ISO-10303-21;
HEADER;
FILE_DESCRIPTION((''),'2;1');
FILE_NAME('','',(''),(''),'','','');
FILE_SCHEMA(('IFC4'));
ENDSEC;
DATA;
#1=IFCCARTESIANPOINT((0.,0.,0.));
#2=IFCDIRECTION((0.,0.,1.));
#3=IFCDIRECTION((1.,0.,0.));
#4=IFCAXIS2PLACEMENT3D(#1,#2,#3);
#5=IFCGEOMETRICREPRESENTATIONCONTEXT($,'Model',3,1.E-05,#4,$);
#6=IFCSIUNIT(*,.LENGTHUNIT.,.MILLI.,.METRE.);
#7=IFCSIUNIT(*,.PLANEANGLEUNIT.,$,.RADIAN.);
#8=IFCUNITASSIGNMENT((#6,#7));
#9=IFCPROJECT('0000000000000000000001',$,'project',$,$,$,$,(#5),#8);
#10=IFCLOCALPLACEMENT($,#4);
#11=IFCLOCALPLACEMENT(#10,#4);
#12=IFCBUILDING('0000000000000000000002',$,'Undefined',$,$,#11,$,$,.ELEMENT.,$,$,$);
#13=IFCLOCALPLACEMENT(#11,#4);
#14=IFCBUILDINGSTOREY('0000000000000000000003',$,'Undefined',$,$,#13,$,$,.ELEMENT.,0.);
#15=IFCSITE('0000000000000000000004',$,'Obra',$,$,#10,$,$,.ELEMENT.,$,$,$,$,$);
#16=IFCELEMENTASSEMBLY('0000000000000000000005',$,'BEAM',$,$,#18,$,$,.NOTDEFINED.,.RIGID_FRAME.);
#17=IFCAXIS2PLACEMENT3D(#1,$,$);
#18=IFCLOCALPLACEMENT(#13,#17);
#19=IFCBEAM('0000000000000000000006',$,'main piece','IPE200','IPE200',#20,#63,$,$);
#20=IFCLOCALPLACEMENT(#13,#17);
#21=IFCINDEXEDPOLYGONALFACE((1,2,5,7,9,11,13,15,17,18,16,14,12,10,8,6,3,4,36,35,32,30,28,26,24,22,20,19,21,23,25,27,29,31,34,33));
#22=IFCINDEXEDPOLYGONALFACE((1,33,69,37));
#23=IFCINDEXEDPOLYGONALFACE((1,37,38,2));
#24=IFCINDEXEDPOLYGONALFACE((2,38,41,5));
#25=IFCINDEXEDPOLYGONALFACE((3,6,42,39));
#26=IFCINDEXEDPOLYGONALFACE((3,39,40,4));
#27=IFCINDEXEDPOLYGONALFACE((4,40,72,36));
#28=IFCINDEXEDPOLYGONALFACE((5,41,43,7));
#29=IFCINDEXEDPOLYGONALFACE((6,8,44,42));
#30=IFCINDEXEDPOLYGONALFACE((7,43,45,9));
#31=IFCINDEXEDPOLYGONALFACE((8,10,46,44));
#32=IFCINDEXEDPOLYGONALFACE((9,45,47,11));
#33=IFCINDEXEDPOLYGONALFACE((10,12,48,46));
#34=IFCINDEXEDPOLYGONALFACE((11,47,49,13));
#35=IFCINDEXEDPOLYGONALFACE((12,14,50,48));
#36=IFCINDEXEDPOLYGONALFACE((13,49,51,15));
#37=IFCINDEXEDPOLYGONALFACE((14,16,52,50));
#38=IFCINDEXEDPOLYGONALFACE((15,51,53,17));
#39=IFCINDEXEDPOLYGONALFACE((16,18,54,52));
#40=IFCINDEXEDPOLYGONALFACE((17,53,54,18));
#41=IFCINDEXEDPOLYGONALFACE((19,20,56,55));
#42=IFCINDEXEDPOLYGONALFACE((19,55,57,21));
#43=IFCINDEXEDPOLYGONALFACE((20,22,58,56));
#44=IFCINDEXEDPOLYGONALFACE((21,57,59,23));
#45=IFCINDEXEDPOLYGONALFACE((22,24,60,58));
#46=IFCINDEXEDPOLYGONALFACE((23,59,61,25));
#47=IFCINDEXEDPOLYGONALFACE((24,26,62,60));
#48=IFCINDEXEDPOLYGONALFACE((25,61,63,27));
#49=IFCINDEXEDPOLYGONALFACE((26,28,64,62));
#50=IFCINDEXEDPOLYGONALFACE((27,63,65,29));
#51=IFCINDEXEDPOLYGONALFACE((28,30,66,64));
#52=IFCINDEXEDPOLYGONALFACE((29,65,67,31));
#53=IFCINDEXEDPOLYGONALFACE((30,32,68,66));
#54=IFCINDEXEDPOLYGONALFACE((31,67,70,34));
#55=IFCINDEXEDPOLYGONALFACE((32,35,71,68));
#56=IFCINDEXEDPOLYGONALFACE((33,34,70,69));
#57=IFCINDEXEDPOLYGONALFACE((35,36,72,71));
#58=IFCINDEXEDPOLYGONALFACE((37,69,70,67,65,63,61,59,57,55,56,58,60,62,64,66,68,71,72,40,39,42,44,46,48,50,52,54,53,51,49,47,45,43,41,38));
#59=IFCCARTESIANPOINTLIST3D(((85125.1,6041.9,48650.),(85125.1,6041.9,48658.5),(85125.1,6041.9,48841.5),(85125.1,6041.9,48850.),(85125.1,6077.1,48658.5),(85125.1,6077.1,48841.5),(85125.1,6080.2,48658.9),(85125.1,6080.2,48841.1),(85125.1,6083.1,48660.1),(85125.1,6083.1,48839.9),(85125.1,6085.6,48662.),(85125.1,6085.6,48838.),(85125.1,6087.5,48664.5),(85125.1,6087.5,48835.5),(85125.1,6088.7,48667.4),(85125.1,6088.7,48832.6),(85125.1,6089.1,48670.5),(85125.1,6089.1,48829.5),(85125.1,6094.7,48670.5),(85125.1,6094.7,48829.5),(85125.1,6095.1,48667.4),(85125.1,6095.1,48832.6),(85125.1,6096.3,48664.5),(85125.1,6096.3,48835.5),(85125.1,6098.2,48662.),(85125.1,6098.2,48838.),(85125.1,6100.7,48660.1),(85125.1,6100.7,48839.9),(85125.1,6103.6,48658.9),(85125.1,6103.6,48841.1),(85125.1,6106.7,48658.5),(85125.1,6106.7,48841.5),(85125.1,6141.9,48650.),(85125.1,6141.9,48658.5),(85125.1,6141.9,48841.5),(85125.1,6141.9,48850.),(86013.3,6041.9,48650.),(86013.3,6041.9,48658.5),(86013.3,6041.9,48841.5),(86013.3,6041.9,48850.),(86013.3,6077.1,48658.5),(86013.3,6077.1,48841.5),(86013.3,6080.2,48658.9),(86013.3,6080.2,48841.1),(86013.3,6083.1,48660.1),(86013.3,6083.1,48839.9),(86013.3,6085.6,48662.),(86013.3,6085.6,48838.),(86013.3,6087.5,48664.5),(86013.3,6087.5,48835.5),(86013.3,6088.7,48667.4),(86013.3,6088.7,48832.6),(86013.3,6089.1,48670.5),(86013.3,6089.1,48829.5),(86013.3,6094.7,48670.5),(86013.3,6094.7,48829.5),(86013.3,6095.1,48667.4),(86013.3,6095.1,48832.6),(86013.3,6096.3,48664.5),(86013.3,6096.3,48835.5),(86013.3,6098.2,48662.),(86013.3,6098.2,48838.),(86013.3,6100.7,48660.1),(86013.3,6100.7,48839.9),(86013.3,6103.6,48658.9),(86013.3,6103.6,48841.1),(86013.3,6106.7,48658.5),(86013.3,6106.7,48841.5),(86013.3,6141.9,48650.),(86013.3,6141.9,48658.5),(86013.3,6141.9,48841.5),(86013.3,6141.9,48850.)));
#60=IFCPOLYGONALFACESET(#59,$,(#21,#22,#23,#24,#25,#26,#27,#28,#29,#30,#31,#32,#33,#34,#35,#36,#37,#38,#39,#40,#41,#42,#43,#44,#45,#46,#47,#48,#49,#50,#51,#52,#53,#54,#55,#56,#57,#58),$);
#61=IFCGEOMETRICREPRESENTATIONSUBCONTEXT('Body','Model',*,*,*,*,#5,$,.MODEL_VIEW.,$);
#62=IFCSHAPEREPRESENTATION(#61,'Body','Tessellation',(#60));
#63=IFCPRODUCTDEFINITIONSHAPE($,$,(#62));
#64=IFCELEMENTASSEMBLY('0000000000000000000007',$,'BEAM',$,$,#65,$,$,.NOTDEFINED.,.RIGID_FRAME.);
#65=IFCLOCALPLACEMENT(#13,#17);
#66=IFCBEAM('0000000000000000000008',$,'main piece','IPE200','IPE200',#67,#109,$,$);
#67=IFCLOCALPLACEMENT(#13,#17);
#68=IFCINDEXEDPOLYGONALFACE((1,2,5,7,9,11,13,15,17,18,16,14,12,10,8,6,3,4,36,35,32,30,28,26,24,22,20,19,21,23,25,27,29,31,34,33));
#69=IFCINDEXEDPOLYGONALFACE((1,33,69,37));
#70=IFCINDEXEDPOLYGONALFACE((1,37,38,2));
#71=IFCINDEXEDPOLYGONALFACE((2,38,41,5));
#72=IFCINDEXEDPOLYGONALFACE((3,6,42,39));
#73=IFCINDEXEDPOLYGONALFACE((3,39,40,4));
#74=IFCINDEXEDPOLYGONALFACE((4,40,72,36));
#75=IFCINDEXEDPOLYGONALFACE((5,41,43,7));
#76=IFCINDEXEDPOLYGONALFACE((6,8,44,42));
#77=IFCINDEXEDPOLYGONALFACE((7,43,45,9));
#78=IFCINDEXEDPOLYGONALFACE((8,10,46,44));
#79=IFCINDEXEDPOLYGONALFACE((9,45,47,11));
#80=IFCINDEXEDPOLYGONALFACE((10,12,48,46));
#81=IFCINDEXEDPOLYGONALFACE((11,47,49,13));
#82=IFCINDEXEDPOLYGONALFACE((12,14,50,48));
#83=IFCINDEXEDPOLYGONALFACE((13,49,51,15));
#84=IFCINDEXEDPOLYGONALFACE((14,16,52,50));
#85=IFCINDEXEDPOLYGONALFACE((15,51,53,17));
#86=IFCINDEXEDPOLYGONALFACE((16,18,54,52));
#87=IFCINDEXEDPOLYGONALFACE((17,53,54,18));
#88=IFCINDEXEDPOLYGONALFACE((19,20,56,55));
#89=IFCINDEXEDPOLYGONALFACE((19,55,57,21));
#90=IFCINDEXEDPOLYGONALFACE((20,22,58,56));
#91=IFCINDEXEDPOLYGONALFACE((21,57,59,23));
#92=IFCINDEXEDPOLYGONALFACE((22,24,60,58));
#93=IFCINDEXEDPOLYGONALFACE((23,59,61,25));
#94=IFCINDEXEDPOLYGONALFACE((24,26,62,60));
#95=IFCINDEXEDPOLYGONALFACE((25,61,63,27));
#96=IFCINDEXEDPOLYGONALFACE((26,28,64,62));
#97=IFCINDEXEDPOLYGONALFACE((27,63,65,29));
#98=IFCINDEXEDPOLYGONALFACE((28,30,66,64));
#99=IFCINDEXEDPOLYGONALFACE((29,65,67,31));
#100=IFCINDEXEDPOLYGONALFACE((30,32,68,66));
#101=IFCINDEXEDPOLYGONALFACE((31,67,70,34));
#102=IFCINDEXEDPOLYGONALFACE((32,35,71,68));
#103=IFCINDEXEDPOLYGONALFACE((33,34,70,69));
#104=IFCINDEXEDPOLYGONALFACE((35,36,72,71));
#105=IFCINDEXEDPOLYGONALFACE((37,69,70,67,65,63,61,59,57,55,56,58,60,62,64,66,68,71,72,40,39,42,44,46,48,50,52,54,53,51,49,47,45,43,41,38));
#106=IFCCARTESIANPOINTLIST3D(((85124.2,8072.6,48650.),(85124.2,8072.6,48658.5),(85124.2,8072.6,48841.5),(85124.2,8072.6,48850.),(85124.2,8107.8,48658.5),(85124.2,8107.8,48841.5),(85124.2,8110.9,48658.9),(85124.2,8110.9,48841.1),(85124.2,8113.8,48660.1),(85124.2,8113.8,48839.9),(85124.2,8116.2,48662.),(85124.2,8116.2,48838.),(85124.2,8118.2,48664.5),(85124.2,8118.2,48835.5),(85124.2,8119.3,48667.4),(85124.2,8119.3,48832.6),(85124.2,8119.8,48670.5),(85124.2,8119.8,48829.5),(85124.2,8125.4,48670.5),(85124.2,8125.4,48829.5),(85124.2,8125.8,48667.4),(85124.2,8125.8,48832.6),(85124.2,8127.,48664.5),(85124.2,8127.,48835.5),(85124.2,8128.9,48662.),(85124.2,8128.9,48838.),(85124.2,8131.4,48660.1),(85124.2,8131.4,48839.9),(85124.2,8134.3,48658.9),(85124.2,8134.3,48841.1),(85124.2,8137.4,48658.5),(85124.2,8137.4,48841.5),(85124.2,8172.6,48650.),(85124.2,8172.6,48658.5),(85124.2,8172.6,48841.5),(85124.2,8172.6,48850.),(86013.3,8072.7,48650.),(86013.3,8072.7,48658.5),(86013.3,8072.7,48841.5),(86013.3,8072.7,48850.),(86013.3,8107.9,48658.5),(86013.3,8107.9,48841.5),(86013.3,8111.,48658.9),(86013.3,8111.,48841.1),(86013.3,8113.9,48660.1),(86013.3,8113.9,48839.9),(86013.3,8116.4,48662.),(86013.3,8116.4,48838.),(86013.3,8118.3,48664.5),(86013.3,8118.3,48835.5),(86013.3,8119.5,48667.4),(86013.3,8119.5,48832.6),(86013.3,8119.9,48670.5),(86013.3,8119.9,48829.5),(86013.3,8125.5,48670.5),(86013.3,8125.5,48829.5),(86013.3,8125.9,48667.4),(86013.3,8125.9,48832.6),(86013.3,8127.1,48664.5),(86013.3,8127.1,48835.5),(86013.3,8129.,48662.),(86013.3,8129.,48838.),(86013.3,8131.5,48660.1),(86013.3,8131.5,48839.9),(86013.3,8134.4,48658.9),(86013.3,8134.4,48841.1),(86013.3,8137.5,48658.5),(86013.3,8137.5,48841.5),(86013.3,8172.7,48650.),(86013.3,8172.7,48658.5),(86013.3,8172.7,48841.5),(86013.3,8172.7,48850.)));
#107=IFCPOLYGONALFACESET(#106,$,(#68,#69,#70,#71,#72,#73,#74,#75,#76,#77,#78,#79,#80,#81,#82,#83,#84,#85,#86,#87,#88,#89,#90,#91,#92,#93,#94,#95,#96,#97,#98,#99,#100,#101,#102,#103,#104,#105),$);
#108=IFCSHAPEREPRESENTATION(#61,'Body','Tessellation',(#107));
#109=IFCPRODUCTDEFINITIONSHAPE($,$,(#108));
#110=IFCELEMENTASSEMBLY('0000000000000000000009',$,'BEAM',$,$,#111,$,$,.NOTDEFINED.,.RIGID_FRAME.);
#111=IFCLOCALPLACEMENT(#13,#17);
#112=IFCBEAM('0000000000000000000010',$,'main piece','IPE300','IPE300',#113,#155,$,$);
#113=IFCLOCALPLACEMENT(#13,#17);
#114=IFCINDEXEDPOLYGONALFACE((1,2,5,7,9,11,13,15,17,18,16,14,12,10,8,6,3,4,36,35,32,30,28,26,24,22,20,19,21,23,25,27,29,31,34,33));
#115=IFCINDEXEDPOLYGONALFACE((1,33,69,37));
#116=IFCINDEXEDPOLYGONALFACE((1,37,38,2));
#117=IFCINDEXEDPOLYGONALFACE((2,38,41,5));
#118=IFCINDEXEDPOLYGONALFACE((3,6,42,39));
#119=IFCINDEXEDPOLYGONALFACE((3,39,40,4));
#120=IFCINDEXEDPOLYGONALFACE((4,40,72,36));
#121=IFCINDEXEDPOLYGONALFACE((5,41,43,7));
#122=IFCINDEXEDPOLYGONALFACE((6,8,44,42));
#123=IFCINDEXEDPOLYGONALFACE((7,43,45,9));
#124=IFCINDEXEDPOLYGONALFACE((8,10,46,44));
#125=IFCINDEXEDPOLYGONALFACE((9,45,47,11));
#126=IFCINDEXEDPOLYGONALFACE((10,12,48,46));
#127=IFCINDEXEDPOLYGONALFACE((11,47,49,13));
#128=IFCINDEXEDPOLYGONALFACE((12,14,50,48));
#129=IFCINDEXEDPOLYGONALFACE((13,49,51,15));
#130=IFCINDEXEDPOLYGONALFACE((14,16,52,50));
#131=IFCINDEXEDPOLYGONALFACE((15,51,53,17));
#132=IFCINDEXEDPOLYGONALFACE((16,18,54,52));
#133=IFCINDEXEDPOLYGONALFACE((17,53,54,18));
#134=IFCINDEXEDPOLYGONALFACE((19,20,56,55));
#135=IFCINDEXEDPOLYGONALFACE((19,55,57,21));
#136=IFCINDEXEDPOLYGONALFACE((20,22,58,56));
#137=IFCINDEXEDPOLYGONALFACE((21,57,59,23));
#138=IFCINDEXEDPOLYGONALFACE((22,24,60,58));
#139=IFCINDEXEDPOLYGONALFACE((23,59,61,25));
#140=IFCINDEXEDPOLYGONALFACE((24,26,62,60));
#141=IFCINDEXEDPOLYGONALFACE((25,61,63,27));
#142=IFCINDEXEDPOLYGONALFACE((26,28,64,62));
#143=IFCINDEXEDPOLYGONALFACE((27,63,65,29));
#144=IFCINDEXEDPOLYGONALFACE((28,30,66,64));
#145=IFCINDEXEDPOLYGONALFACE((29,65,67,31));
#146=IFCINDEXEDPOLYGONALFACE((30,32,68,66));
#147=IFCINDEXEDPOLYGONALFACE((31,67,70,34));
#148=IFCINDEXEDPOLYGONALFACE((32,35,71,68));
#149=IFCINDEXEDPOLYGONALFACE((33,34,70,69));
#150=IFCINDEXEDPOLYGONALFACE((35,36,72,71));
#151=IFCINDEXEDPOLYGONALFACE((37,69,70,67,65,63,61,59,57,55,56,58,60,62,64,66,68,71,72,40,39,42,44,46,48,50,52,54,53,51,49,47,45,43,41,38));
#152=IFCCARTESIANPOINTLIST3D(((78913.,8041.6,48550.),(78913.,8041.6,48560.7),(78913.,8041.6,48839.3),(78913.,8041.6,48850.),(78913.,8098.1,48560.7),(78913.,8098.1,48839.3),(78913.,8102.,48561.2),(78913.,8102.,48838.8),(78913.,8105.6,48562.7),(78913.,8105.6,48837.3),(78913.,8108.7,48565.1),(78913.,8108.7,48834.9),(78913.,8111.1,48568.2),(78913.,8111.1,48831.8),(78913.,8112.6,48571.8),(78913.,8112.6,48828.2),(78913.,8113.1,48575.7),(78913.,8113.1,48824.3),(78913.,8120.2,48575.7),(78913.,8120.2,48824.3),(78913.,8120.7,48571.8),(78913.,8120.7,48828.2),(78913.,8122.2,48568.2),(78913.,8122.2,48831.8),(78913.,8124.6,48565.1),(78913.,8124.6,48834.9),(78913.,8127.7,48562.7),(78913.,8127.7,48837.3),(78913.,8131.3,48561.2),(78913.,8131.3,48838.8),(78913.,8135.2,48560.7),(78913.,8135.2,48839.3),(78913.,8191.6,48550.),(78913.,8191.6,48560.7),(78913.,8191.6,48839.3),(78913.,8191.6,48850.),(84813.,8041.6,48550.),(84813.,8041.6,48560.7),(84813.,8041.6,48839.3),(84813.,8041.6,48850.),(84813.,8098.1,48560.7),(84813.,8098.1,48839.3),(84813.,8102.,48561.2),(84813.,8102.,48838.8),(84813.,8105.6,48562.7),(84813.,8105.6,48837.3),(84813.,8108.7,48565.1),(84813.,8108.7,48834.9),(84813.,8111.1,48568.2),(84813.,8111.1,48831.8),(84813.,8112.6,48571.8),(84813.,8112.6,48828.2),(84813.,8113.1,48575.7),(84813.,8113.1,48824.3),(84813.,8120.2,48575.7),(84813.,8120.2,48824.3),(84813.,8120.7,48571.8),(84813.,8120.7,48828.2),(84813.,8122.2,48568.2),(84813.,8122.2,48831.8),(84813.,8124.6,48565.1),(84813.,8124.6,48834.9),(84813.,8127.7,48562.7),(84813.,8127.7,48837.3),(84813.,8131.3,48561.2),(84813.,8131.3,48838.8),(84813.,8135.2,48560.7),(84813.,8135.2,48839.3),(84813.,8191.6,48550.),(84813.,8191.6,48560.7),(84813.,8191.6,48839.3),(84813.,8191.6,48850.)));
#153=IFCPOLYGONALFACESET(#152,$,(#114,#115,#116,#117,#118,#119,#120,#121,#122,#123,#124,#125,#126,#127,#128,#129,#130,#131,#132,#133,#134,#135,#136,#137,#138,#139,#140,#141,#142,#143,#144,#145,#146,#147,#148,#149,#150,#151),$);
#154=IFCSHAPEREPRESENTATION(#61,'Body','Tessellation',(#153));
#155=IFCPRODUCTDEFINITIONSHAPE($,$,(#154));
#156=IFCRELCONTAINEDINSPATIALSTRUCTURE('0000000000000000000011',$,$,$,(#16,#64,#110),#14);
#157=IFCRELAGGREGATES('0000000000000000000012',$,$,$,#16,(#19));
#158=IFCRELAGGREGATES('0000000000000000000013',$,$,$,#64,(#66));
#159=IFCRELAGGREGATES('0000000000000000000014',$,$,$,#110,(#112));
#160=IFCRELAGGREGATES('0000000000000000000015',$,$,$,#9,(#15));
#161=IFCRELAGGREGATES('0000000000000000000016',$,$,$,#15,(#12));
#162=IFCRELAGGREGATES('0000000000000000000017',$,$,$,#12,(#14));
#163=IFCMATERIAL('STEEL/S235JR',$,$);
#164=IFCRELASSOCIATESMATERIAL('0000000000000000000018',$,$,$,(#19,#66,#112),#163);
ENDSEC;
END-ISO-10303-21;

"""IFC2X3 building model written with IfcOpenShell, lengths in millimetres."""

from ifc_helpers import new_model, si_unit, frame, origin_with_axes, origin_2d_with_axis, place, context, subcontext, project, spatial, i_section, extrude, material, element, aggregate, save


model = new_model("IFC2X3")

# Units and contexts
model_context = context("Model", 3, precision=1e-05, world=origin_with_axes())
body_context = subcontext(model_context, "Body", "Model", "MODEL_VIEW")
ifc_project = project(units=[si_unit("LENGTHUNIT", "METRE", prefix="MILLI"), si_unit("PLANEANGLEUNIT", "RADIAN")], contexts=[model_context])

# Site, building, storey
site_placement = place(None, origin_with_axes())
site = spatial("IfcSite", under=ifc_project, at=site_placement, Name="Obra", CompositionType="ELEMENT")
building_placement = place(site_placement, origin_with_axes())
building = spatial("IfcBuilding", under=site, at=building_placement, Name="Undefined", CompositionType="ELEMENT")
storey_placement = place(building_placement, origin_with_axes())
storey = spatial("IfcBuildingStorey", under=building, at=storey_placement, Name="Undefined", CompositionType="ELEMENT", Elevation=0.0)

# Shared definitions
ifc_material_1 = material(Name="STEEL/S235JR")

# Element assemblies, beams
assembly_1_placement = place(storey_placement, origin_with_axes())
assembly_1 = element("IfcElementAssembly", 1, at=assembly_1_placement, inside=storey, Name="BEAM", AssemblyPlace="NOTDEFINED", PredefinedType="RIGID_FRAME")
beam_1_placement = place(assembly_1_placement, frame((85125.0, 6091.9, 48750.0), z_axis=(0.0, 0.0, 1.0), x_axis=(1.0, 0.0, 0.0)))
beam_1 = element("IfcBeam", 2, at=beam_1_placement, material=ifc_material_1, Name="main piece", Description="IPE200", ObjectType="IPE200", context=body_context, shape_type="SweptSolid", body=[
    extrude(i_section(OverallWidth=100.0, OverallDepth=200.0, WebThickness=5.6, FlangeThickness=8.5, FilletRadius=12.0, at=origin_2d_with_axis()), frame((888.3, 0.0, 0.0), z_axis=(-1.0, 0.0, 0.0), x_axis=(0.0, -1.0, 0.0)), (0.0, 0.0, 1.0), 888.2),
])
aggregate(assembly_1, [beam_1])
assembly_2_placement = place(storey_placement, origin_with_axes())
assembly_2 = element("IfcElementAssembly", 3, at=assembly_2_placement, inside=storey, Name="BEAM", AssemblyPlace="NOTDEFINED", PredefinedType="RIGID_FRAME")
beam_2_placement = place(assembly_2_placement, frame((85124.2, 8122.6, 48750.0), z_axis=(0.0, 0.0, 1.0), x_axis=(1.0, 0.000161, 0.0)))
beam_2 = element("IfcBeam", 4, at=beam_2_placement, material=ifc_material_1, Name="main piece", Description="IPE200", ObjectType="IPE200", context=body_context, shape_type="SweptSolid", body=[
    extrude(i_section(OverallWidth=100.0, OverallDepth=200.0, WebThickness=5.6, FlangeThickness=8.5, FilletRadius=12.0, at=origin_2d_with_axis()), frame((889.1, 0.0, 0.0), z_axis=(-1.0, 0.0, 0.0), x_axis=(0.0, -1.0, 0.0)), (0.0, 0.0, 1.0), 889.1),
])
aggregate(assembly_2, [beam_2])
assembly_3_placement = place(storey_placement, origin_with_axes())
assembly_3 = element("IfcElementAssembly", 5, at=assembly_3_placement, inside=storey, Name="BEAM", AssemblyPlace="NOTDEFINED", PredefinedType="RIGID_FRAME")
beam_3_placement = place(assembly_3_placement, frame((78913.0, 8116.6, 48700.0), z_axis=(0.0, 0.0, 1.0), x_axis=(1.0, 0.0, 0.0)))
beam_3 = element("IfcBeam", 6, at=beam_3_placement, material=ifc_material_1, Name="main piece", Description="IPE300", ObjectType="IPE300", context=body_context, shape_type="SweptSolid", body=[
    extrude(i_section(OverallWidth=150.0, OverallDepth=300.0, WebThickness=7.1, FlangeThickness=10.7, FilletRadius=15.0, at=origin_2d_with_axis()), frame((5900.0, 0.0, 0.0), z_axis=(-1.0, 0.0, 0.0), x_axis=(0.0, -1.0, 0.0)), (0.0, 0.0, 1.0), 5900.0),
])
aggregate(assembly_3, [beam_3])

save(model, "model.ifc")
